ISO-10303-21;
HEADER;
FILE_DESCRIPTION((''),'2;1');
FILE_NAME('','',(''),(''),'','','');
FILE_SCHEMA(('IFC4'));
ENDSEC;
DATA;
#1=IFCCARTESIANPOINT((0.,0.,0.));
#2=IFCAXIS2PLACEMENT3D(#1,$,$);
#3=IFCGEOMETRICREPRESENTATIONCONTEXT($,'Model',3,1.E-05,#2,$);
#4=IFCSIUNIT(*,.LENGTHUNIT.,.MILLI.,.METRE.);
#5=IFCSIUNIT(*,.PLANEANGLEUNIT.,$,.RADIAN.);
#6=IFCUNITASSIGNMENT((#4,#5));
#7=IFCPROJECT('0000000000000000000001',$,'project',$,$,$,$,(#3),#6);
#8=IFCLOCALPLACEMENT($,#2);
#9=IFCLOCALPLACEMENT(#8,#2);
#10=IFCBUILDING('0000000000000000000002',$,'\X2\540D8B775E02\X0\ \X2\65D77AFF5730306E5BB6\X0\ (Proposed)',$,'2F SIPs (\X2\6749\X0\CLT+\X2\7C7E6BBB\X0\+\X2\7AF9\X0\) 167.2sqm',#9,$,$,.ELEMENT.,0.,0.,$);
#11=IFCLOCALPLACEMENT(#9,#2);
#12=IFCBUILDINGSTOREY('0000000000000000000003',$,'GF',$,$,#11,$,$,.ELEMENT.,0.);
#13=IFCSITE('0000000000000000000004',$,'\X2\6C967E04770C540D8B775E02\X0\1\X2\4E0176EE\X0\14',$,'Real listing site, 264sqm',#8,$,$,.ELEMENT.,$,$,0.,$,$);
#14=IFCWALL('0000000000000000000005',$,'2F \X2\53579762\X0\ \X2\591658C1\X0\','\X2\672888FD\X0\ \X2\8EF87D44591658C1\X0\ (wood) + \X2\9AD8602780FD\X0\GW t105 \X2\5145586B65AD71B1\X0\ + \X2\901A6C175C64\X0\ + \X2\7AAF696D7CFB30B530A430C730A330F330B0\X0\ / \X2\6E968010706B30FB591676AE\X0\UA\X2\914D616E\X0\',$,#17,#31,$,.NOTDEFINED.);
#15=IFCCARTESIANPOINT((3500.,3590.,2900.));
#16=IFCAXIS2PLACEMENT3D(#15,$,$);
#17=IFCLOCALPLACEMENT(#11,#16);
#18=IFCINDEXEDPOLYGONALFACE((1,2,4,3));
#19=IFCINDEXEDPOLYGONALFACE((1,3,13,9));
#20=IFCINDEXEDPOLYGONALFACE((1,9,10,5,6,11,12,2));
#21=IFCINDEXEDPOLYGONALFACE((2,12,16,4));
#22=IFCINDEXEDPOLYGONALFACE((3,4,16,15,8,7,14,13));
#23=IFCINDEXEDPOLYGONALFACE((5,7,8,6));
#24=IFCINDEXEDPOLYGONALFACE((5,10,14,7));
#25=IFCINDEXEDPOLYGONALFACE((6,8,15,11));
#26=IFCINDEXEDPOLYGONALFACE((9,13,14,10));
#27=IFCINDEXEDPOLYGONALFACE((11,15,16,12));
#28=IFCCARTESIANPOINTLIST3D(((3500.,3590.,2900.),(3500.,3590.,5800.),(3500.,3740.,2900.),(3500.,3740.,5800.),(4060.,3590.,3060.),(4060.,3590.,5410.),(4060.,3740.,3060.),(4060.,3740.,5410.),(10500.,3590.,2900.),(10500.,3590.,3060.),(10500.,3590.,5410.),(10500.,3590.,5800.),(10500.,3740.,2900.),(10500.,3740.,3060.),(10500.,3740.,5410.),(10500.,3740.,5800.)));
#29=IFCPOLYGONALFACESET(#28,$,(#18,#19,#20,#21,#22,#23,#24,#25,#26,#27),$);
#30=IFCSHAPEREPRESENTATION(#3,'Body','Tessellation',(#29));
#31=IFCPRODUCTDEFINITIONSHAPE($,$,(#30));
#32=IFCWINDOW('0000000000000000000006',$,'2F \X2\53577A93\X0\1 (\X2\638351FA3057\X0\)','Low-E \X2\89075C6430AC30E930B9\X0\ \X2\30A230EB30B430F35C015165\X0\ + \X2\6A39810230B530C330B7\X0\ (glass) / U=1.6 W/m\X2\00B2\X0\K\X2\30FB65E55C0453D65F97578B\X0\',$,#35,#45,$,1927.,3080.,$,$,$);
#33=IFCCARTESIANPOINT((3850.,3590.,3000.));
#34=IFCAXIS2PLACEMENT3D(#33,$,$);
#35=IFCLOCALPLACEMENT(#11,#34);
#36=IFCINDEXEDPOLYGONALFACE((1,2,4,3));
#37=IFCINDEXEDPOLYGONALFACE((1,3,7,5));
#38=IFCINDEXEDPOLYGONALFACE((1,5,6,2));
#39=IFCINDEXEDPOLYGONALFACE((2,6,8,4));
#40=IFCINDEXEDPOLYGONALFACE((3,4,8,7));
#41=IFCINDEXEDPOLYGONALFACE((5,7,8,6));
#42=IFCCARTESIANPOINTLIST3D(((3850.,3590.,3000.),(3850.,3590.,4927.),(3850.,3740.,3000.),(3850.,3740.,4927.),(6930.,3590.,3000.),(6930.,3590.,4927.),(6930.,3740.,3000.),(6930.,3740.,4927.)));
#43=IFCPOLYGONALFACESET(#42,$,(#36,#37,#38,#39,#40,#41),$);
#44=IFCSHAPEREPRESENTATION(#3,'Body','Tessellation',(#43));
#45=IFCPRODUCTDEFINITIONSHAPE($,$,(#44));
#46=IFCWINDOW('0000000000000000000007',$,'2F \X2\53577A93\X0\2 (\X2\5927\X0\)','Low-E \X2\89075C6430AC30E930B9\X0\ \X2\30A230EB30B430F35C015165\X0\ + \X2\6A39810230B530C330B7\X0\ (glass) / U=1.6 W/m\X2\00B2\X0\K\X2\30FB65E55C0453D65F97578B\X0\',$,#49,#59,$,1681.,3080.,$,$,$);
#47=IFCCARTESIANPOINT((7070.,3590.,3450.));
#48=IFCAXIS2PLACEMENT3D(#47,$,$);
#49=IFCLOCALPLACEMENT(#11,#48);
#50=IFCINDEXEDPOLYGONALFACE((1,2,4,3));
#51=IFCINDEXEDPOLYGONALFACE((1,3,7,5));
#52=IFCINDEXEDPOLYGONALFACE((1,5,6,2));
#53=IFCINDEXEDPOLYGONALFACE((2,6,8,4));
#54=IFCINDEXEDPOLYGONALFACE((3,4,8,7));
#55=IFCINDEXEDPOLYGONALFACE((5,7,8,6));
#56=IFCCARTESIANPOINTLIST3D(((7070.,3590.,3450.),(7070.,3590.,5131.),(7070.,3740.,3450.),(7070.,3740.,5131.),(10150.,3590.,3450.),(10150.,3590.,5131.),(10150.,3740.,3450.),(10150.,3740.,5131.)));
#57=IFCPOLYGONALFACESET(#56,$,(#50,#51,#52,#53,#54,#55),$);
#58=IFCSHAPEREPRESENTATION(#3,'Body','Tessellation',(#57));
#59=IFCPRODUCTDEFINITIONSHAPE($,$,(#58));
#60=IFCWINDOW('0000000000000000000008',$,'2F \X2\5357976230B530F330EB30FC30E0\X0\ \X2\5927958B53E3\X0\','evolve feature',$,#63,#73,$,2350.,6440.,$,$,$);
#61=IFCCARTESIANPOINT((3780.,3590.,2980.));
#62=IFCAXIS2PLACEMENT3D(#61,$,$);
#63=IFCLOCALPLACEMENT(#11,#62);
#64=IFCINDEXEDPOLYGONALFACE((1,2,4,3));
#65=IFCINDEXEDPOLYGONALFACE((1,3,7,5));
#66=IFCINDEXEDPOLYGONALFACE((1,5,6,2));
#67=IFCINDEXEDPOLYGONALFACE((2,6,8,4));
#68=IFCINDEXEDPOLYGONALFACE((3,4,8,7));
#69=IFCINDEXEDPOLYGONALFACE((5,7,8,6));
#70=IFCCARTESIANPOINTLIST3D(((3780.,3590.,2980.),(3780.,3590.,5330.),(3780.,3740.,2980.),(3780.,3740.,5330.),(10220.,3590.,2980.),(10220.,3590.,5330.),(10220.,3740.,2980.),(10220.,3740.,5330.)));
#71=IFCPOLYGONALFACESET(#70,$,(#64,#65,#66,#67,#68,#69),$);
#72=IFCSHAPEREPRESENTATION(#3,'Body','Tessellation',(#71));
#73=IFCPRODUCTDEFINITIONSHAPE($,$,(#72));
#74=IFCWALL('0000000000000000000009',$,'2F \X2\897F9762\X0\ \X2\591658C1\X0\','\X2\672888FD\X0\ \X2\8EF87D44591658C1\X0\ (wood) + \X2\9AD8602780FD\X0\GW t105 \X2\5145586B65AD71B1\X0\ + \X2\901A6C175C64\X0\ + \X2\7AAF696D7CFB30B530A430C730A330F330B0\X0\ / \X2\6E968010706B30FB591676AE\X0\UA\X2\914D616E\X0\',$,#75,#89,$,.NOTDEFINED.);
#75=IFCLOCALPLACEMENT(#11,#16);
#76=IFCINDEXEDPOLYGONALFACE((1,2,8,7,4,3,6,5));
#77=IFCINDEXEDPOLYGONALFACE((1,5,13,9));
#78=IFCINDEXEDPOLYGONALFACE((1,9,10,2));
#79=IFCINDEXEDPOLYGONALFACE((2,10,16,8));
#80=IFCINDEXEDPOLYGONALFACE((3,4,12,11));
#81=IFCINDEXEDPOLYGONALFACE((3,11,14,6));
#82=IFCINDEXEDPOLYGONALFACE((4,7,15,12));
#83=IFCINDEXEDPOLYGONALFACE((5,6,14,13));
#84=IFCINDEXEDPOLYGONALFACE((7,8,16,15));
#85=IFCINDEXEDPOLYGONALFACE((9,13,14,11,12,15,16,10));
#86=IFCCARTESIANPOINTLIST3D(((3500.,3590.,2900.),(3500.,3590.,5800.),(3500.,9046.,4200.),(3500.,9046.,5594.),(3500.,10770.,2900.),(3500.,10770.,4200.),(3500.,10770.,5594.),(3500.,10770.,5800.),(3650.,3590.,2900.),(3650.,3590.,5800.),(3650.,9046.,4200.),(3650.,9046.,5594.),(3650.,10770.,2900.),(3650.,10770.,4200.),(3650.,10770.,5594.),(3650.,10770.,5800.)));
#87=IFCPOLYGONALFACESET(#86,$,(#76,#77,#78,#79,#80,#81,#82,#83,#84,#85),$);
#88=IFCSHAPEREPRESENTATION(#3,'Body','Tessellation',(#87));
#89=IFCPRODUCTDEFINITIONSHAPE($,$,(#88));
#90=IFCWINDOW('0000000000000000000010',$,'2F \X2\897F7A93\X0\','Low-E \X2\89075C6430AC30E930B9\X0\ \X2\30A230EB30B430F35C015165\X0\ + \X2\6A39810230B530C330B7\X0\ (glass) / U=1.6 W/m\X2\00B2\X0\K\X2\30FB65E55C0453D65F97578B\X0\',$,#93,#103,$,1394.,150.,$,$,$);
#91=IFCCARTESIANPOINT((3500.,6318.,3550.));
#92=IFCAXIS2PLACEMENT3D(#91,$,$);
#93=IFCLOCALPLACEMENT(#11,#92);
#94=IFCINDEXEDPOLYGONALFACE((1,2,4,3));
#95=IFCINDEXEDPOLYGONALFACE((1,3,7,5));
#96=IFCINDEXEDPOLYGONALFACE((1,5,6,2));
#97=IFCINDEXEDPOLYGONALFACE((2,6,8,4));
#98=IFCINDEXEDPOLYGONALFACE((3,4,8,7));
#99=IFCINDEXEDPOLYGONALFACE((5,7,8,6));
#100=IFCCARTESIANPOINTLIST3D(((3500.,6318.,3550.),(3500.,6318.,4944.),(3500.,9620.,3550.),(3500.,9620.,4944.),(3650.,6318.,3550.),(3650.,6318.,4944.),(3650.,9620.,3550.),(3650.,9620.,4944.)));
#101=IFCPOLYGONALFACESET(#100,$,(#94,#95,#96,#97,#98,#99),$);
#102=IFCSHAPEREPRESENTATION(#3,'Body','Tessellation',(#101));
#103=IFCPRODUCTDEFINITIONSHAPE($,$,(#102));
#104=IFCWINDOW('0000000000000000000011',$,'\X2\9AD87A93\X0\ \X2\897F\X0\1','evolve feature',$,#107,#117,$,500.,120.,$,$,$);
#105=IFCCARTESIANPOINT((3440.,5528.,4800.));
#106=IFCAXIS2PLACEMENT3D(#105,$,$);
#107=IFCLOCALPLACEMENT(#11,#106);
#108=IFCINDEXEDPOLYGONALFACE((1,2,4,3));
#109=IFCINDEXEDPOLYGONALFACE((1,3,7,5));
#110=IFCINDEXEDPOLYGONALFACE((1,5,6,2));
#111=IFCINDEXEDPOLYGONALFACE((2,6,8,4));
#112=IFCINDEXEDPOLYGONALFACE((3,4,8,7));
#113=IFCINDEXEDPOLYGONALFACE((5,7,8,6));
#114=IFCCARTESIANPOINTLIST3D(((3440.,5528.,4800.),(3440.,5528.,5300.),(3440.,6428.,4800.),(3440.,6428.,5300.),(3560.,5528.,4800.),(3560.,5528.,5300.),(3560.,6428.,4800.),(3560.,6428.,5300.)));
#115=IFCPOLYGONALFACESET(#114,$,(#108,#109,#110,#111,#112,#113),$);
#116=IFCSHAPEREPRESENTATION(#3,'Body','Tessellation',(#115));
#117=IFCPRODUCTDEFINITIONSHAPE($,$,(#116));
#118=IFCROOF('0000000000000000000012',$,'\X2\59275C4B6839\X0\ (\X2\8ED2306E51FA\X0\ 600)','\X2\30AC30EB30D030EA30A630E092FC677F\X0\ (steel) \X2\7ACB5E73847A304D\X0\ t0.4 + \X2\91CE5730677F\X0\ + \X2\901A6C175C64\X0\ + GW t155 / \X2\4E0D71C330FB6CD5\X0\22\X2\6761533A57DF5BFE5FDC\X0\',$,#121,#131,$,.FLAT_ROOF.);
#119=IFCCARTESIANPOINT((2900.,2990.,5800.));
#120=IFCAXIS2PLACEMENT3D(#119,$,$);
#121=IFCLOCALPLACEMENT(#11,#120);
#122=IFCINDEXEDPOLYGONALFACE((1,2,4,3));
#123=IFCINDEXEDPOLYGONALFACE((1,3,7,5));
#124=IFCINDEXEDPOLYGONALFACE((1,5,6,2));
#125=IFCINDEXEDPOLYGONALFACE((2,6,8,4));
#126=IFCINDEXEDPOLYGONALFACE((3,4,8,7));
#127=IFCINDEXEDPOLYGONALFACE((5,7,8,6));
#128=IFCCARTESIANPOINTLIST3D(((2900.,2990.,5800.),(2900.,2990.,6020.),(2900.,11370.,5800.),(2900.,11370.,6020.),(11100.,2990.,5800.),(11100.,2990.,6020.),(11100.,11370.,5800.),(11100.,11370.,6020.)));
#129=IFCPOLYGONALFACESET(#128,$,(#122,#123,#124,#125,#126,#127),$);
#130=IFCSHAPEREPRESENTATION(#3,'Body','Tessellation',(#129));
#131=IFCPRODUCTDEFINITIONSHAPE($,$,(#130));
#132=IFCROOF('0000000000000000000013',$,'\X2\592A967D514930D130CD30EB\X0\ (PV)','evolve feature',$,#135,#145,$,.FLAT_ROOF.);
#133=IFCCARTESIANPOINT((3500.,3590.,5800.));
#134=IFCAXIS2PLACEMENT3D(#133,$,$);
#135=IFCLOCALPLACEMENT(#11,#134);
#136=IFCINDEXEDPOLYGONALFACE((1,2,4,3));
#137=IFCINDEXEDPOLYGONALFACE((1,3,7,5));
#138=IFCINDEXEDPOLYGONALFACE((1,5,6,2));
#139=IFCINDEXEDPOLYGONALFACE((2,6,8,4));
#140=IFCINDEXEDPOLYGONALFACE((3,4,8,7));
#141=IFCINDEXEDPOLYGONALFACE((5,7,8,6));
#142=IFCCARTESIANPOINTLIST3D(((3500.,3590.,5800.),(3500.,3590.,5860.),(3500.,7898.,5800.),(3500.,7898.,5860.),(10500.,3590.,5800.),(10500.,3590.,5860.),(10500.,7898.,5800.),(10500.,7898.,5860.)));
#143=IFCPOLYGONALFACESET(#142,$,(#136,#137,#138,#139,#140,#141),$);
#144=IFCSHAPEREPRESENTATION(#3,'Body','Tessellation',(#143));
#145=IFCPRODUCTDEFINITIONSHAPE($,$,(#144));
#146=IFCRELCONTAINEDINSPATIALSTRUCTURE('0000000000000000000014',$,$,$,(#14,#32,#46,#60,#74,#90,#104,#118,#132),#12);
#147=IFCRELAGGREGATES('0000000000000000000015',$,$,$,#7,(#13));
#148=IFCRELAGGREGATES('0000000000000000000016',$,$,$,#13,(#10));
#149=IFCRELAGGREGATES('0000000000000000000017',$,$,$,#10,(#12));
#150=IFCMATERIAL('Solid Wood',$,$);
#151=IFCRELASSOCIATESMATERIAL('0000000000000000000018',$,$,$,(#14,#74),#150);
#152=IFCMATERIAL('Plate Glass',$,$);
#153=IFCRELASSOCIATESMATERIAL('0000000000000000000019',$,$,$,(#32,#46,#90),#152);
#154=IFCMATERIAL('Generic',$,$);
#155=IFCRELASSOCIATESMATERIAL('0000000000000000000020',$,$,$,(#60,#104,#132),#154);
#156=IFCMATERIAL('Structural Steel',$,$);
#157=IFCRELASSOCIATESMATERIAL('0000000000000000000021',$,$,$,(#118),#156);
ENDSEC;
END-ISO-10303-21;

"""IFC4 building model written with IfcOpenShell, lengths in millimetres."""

from ifc_helpers import new_model, si_unit, frame, frame_2d, origin, place, context, project, spatial, rectangle, extrude, material, element, fill, save


model = new_model("IFC4")

# Units and contexts
model_context = context("Model", 3, precision=1e-05, world=origin())
ifc_project = project(units=[si_unit("LENGTHUNIT", "METRE", prefix="MILLI"), si_unit("PLANEANGLEUNIT", "RADIAN")], contexts=[model_context])

# Site, building, storey
site_placement = place(None, origin())
site = spatial("IfcSite", under=ifc_project, at=site_placement, Name="沖縄県名護市1丁目14", ObjectType="Real listing site, 264sqm", CompositionType="ELEMENT", RefElevation=0.0)
building_placement = place(site_placement, origin())
building = spatial("IfcBuilding", under=site, at=building_placement, Name="名護市 旗竿地の家 (Proposed)", ObjectType="2F SIPs (杉CLT+籾殻+竹) 167.2sqm", CompositionType="ELEMENT", ElevationOfRefHeight=0.0, ElevationOfTerrain=0.0)
storey_placement = place(building_placement, origin())
storey = spatial("IfcBuildingStorey", under=building, at=storey_placement, Name="GF", CompositionType="ELEMENT", Elevation=0.0)

# Shared definitions
ifc_material_1 = material(Name="Solid Wood")
ifc_material_2 = material(Name="Generic")

# Shared definitions
ifc_material_3 = material(Name="Plate Glass")

# Walls, openings, windows
wall_1_placement = place(storey_placement, frame((3500.0, 3590.0, 2900.0)))
wall_1 = element("IfcWall", 1, at=wall_1_placement, inside=storey, material=ifc_material_1, Name="2F 南面 外壁", Description="木製 軸組外壁 (wood) + 高性能GW t105 充填断熱 + 通気層 + 窯業系サイディング / 準耐火・外皮UA配慮", PredefinedType="NOTDEFINED", context=model_context, shape_type="SweptSolid", body=[
    extrude(rectangle(XDim=7000.0, YDim=150.0, at=frame_2d((3500.0, 75.0))), frame((3500.0, 3590.0, 2900.0)), (0.0, 0.0, 1.0), 2900.0),
])
opening_1_placement = place(storey_placement, frame((3850.0, 3590.0, 3000.0)))
opening_1 = element("IfcOpeningElement", 2, at=opening_1_placement, cuts=wall_1, PredefinedType="NOTDEFINED", context=model_context, shape_type="SweptSolid", body=[
    extrude(rectangle(XDim=3080.0, YDim=150.0, at=frame_2d((1540.0, 75.0))), frame((3850.0, 3590.0, 3000.0)), (0.0, 0.0, 1.0), 1927.0),
])
opening_2_placement = place(storey_placement, frame((7070.0, 3590.0, 3450.0)))
opening_2 = element("IfcOpeningElement", 3, at=opening_2_placement, cuts=wall_1, PredefinedType="NOTDEFINED", context=model_context, shape_type="SweptSolid", body=[
    extrude(rectangle(XDim=3080.0, YDim=150.0, at=frame_2d((1540.0, 75.0))), frame((7070.0, 3590.0, 3450.0)), (0.0, 0.0, 1.0), 1681.0),
])
opening_3_placement = place(storey_placement, frame((3780.0, 3590.0, 2980.0)))
opening_3 = element("IfcOpeningElement", 4, at=opening_3_placement, cuts=wall_1, PredefinedType="NOTDEFINED", context=model_context, shape_type="SweptSolid", body=[
    extrude(rectangle(XDim=6440.0, YDim=150.0, at=frame_2d((3220.0, 75.0))), frame((3780.0, 3590.0, 2980.0)), (0.0, 0.0, 1.0), 2350.0),
])
window_1_placement = place(storey_placement, frame((3850.0, 3590.0, 3000.0)))
window_1 = element("IfcWindow", 5, at=window_1_placement, inside=storey, material=ifc_material_3, Name="2F 南窓1 (掃出し)", Description="Low-E 複層ガラス アルゴン封入 + 樹脂サッシ (glass) / U=1.6 W/m²K・日射取得型", OverallHeight=1927.0, OverallWidth=3080.0, context=model_context, shape_type="SweptSolid", body=[
    extrude(rectangle(XDim=3080.0, YDim=150.0, at=frame_2d((1540.0, 75.0))), frame((3850.0, 3590.0, 3000.0)), (0.0, 0.0, 1.0), 1927.0),
])
fill(opening_1, window_1)
window_2_placement = place(storey_placement, frame((7070.0, 3590.0, 3450.0)))
window_2 = element("IfcWindow", 6, at=window_2_placement, inside=storey, material=ifc_material_3, Name="2F 南窓2 (大)", Description="Low-E 複層ガラス アルゴン封入 + 樹脂サッシ (glass) / U=1.6 W/m²K・日射取得型", OverallHeight=1681.0, OverallWidth=3080.0, context=model_context, shape_type="SweptSolid", body=[
    extrude(rectangle(XDim=3080.0, YDim=150.0, at=frame_2d((1540.0, 75.0))), frame((7070.0, 3590.0, 3450.0)), (0.0, 0.0, 1.0), 1681.0),
])
fill(opening_2, window_2)
window_3_placement = place(storey_placement, frame((3780.0, 3590.0, 2980.0)))
window_3 = element("IfcWindow", 7, at=window_3_placement, inside=storey, material=ifc_material_2, Name="2F 南面サンルーム 大開口", Description="evolve feature", OverallHeight=2350.0, OverallWidth=6440.0, context=model_context, shape_type="SweptSolid", body=[
    extrude(rectangle(XDim=6440.0, YDim=150.0, at=frame_2d((3220.0, 75.0))), frame((3780.0, 3590.0, 2980.0)), (0.0, 0.0, 1.0), 2350.0),
])
fill(opening_3, window_3)
wall_2_placement = place(storey_placement, frame((3500.0, 3590.0, 2900.0)))
wall_2 = element("IfcWall", 8, at=wall_2_placement, inside=storey, material=ifc_material_1, Name="2F 西面 外壁", Description="木製 軸組外壁 (wood) + 高性能GW t105 充填断熱 + 通気層 + 窯業系サイディング / 準耐火・外皮UA配慮", PredefinedType="NOTDEFINED", context=model_context, shape_type="SweptSolid", body=[
    extrude(rectangle(XDim=150.0, YDim=7180.0, at=frame_2d((75.0, 3590.0))), frame((3500.0, 3590.0, 2900.0)), (0.0, 0.0, 1.0), 2900.0),
])
opening_4_placement = place(storey_placement, frame((3500.0, 6318.0, 3550.0)))
opening_4 = element("IfcOpeningElement", 9, at=opening_4_placement, cuts=wall_2, PredefinedType="NOTDEFINED", context=model_context, shape_type="SweptSolid", body=[
    extrude(rectangle(XDim=150.0, YDim=3302.0, at=frame_2d((75.0, 1651.0))), frame((3500.0, 6318.0, 3550.0)), (0.0, 0.0, 1.0), 1394.0),
])
opening_5_placement = place(storey_placement, frame((3440.0, 5528.0, 4800.0)))
opening_5 = element("IfcOpeningElement", 10, at=opening_5_placement, cuts=wall_2, PredefinedType="NOTDEFINED", context=model_context, shape_type="SweptSolid", body=[
    extrude(rectangle(XDim=120.0, YDim=900.0, at=frame_2d((60.0, 450.0))), frame((3440.0, 5528.0, 4800.0)), (0.0, 0.0, 1.0), 500.0),
])
window_4_placement = place(storey_placement, frame((3500.0, 6318.0, 3550.0)))
window_4 = element("IfcWindow", 11, at=window_4_placement, inside=storey, material=ifc_material_3, Name="2F 西窓", Description="Low-E 複層ガラス アルゴン封入 + 樹脂サッシ (glass) / U=1.6 W/m²K・日射取得型", OverallHeight=1394.0, OverallWidth=150.0, context=model_context, shape_type="SweptSolid", body=[
    extrude(rectangle(XDim=150.0, YDim=3302.0, at=frame_2d((75.0, 1651.0))), frame((3500.0, 6318.0, 3550.0)), (0.0, 0.0, 1.0), 1394.0),
])
fill(opening_4, window_4)
window_5_placement = place(storey_placement, frame((3440.0, 5528.0, 4800.0)))
window_5 = element("IfcWindow", 12, at=window_5_placement, inside=storey, material=ifc_material_2, Name="高窓 西1", Description="evolve feature", OverallHeight=500.0, OverallWidth=120.0, context=model_context, shape_type="SweptSolid", body=[
    extrude(rectangle(XDim=120.0, YDim=900.0, at=frame_2d((60.0, 450.0))), frame((3440.0, 5528.0, 4800.0)), (0.0, 0.0, 1.0), 500.0),
])
fill(opening_5, window_5)

# Roofs
ifc_material_4 = material(Name="Structural Steel")
roof_1_placement = place(storey_placement, frame((2900.0, 2990.0, 5800.0)))
element("IfcRoof", 13, at=roof_1_placement, inside=storey, material=ifc_material_4, Name="大屋根 (軒の出 600)", Description="ガルバリウム鋼板 (steel) 立平葺き t0.4 + 野地板 + 通気層 + GW t155 / 不燃・法22条区域対応", PredefinedType="FLAT_ROOF", context=model_context, shape_type="SweptSolid", body=[
    extrude(rectangle(XDim=8200.0, YDim=8380.0, at=frame_2d((4100.0, 4190.0))), frame((2900.0, 2990.0, 5800.0)), (0.0, 0.0, 1.0), 220.0),
])
roof_2_placement = place(storey_placement, frame((3500.0, 3590.0, 5800.0)))
element("IfcRoof", 14, at=roof_2_placement, inside=storey, material=ifc_material_2, Name="太陽光パネル (PV)", Description="evolve feature", PredefinedType="FLAT_ROOF", context=model_context, shape_type="SweptSolid", body=[
    extrude(rectangle(XDim=7000.0, YDim=4308.0, at=frame_2d((3500.0, 2154.0))), frame((3500.0, 3590.0, 5800.0)), (0.0, 0.0, 1.0), 60.0),
])

save(model, "model.ifc")
